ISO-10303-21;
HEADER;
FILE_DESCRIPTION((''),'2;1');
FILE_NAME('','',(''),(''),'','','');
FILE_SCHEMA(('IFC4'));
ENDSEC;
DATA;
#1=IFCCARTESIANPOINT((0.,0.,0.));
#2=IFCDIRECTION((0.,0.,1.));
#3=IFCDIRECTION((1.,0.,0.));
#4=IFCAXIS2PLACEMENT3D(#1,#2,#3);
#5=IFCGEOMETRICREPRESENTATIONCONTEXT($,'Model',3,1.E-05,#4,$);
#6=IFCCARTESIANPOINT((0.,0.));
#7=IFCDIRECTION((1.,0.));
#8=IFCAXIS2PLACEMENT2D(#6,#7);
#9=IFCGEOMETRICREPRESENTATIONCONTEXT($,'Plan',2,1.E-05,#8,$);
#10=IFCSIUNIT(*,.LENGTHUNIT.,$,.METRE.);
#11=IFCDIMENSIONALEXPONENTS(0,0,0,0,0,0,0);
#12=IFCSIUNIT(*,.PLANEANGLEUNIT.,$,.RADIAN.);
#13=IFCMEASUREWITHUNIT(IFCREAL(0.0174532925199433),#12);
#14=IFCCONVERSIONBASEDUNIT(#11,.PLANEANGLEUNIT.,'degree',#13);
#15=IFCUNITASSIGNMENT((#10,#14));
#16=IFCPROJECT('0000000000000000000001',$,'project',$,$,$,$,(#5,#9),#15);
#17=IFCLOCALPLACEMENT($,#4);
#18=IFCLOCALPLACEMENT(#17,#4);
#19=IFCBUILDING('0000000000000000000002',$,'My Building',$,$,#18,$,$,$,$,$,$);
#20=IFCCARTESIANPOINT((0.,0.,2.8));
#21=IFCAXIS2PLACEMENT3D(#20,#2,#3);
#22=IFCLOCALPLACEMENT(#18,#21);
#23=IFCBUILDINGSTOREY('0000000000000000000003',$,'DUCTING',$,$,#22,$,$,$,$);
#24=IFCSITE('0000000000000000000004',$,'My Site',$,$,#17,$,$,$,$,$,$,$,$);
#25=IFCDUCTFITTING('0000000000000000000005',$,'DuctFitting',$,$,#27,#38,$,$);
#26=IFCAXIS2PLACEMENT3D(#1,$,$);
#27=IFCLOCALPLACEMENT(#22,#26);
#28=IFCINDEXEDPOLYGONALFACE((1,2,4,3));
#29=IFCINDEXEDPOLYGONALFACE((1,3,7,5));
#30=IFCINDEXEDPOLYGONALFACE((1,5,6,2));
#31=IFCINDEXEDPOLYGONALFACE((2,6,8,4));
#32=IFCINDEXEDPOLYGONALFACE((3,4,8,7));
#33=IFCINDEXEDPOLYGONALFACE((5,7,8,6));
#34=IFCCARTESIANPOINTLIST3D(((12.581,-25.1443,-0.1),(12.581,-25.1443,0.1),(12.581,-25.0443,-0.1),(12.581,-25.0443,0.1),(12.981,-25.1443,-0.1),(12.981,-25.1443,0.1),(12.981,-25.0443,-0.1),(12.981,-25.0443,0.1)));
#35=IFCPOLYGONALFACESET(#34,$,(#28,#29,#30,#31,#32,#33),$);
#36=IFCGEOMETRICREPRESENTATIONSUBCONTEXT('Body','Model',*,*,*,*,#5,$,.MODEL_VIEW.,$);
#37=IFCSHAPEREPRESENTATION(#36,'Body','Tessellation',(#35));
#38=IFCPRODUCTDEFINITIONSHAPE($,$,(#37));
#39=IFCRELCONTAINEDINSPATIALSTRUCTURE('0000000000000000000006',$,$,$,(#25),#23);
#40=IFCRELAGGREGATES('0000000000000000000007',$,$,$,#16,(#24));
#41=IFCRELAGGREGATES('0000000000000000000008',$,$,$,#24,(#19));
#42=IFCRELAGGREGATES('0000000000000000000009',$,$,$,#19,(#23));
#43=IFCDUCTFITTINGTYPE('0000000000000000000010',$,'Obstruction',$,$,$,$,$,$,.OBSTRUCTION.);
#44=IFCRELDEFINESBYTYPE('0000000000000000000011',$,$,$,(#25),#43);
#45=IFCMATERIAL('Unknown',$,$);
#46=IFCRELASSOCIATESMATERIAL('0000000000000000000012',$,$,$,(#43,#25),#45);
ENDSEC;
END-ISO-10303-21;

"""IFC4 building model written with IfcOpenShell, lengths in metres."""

from ifc_helpers import new_model, entity, si_unit, converted_unit, frame, origin_with_axes, origin_2d_with_axis, place, context, subcontext, project, spatial, rectangle, extrude, material, material_profile, profile_set, profile_usage, type_object, element, save


model = new_model("IFC4")

# Units and contexts
model_context = context("Model", 3, precision=1e-05, world=origin_with_axes())
plan_context = context("Plan", 2, precision=1e-05, world=origin_2d_with_axis())
body_context = subcontext(model_context, "Body", "Model", "MODEL_VIEW")
ifc_project = project(units=[si_unit("LENGTHUNIT", "METRE"), converted_unit("PLANEANGLEUNIT", "degree", entity("IfcReal", 0.0174532925199433), si_unit("PLANEANGLEUNIT", "RADIAN"), dimensions=[0, 0, 0, 0, 0, 0, 0])], contexts=[model_context, plan_context])

# Site, building, storey
site_placement = place(None, origin_with_axes())
site = spatial("IfcSite", under=ifc_project, at=site_placement, Name="My Site")
building_placement = place(site_placement, origin_with_axes())
building = spatial("IfcBuilding", under=site, at=building_placement, Name="My Building")
storey_placement = place(building_placement, frame((0.0, 0.0, 2.8), z_axis=(0.0, 0.0, 1.0), x_axis=(1.0, 0.0, 0.0)))
storey = spatial("IfcBuildingStorey", under=building, at=storey_placement, Name="DUCTING")

# Shared definitions
ifc_material = material(Name="Unknown")

# Duct fitting
ifc_material_profile_1 = material_profile(ifc_material, rectangle(XDim=0.4, YDim=0.2))
ifc_profile_set_1 = profile_set([ifc_material_profile_1])
duct_fitting_type_1 = type_object("IfcDuctFittingType", Name="Obstruction", PredefinedType="OBSTRUCTION", material=ifc_profile_set_1)
ifc_profile_usage_1 = profile_usage(ifc_profile_set_1, cardinal=5)
duct_fitting_1_placement = place(storey_placement, frame((12.781, -25.1443, 0.0), z_axis=(0.0, 1.0, 0.0), x_axis=(-1.0, 0.0, 0.0)))
element("IfcDuctFitting", 1, at=duct_fitting_1_placement, inside=storey, type_object=duct_fitting_type_1, material=ifc_profile_usage_1, Name="DuctFitting", context=body_context, shape_type="SweptSolid", body=[
    extrude(rectangle(XDim=0.4, YDim=0.2), origin_with_axes(), (0.0, 0.0, 1.0), 0.1),
])

save(model, "model.ifc")
